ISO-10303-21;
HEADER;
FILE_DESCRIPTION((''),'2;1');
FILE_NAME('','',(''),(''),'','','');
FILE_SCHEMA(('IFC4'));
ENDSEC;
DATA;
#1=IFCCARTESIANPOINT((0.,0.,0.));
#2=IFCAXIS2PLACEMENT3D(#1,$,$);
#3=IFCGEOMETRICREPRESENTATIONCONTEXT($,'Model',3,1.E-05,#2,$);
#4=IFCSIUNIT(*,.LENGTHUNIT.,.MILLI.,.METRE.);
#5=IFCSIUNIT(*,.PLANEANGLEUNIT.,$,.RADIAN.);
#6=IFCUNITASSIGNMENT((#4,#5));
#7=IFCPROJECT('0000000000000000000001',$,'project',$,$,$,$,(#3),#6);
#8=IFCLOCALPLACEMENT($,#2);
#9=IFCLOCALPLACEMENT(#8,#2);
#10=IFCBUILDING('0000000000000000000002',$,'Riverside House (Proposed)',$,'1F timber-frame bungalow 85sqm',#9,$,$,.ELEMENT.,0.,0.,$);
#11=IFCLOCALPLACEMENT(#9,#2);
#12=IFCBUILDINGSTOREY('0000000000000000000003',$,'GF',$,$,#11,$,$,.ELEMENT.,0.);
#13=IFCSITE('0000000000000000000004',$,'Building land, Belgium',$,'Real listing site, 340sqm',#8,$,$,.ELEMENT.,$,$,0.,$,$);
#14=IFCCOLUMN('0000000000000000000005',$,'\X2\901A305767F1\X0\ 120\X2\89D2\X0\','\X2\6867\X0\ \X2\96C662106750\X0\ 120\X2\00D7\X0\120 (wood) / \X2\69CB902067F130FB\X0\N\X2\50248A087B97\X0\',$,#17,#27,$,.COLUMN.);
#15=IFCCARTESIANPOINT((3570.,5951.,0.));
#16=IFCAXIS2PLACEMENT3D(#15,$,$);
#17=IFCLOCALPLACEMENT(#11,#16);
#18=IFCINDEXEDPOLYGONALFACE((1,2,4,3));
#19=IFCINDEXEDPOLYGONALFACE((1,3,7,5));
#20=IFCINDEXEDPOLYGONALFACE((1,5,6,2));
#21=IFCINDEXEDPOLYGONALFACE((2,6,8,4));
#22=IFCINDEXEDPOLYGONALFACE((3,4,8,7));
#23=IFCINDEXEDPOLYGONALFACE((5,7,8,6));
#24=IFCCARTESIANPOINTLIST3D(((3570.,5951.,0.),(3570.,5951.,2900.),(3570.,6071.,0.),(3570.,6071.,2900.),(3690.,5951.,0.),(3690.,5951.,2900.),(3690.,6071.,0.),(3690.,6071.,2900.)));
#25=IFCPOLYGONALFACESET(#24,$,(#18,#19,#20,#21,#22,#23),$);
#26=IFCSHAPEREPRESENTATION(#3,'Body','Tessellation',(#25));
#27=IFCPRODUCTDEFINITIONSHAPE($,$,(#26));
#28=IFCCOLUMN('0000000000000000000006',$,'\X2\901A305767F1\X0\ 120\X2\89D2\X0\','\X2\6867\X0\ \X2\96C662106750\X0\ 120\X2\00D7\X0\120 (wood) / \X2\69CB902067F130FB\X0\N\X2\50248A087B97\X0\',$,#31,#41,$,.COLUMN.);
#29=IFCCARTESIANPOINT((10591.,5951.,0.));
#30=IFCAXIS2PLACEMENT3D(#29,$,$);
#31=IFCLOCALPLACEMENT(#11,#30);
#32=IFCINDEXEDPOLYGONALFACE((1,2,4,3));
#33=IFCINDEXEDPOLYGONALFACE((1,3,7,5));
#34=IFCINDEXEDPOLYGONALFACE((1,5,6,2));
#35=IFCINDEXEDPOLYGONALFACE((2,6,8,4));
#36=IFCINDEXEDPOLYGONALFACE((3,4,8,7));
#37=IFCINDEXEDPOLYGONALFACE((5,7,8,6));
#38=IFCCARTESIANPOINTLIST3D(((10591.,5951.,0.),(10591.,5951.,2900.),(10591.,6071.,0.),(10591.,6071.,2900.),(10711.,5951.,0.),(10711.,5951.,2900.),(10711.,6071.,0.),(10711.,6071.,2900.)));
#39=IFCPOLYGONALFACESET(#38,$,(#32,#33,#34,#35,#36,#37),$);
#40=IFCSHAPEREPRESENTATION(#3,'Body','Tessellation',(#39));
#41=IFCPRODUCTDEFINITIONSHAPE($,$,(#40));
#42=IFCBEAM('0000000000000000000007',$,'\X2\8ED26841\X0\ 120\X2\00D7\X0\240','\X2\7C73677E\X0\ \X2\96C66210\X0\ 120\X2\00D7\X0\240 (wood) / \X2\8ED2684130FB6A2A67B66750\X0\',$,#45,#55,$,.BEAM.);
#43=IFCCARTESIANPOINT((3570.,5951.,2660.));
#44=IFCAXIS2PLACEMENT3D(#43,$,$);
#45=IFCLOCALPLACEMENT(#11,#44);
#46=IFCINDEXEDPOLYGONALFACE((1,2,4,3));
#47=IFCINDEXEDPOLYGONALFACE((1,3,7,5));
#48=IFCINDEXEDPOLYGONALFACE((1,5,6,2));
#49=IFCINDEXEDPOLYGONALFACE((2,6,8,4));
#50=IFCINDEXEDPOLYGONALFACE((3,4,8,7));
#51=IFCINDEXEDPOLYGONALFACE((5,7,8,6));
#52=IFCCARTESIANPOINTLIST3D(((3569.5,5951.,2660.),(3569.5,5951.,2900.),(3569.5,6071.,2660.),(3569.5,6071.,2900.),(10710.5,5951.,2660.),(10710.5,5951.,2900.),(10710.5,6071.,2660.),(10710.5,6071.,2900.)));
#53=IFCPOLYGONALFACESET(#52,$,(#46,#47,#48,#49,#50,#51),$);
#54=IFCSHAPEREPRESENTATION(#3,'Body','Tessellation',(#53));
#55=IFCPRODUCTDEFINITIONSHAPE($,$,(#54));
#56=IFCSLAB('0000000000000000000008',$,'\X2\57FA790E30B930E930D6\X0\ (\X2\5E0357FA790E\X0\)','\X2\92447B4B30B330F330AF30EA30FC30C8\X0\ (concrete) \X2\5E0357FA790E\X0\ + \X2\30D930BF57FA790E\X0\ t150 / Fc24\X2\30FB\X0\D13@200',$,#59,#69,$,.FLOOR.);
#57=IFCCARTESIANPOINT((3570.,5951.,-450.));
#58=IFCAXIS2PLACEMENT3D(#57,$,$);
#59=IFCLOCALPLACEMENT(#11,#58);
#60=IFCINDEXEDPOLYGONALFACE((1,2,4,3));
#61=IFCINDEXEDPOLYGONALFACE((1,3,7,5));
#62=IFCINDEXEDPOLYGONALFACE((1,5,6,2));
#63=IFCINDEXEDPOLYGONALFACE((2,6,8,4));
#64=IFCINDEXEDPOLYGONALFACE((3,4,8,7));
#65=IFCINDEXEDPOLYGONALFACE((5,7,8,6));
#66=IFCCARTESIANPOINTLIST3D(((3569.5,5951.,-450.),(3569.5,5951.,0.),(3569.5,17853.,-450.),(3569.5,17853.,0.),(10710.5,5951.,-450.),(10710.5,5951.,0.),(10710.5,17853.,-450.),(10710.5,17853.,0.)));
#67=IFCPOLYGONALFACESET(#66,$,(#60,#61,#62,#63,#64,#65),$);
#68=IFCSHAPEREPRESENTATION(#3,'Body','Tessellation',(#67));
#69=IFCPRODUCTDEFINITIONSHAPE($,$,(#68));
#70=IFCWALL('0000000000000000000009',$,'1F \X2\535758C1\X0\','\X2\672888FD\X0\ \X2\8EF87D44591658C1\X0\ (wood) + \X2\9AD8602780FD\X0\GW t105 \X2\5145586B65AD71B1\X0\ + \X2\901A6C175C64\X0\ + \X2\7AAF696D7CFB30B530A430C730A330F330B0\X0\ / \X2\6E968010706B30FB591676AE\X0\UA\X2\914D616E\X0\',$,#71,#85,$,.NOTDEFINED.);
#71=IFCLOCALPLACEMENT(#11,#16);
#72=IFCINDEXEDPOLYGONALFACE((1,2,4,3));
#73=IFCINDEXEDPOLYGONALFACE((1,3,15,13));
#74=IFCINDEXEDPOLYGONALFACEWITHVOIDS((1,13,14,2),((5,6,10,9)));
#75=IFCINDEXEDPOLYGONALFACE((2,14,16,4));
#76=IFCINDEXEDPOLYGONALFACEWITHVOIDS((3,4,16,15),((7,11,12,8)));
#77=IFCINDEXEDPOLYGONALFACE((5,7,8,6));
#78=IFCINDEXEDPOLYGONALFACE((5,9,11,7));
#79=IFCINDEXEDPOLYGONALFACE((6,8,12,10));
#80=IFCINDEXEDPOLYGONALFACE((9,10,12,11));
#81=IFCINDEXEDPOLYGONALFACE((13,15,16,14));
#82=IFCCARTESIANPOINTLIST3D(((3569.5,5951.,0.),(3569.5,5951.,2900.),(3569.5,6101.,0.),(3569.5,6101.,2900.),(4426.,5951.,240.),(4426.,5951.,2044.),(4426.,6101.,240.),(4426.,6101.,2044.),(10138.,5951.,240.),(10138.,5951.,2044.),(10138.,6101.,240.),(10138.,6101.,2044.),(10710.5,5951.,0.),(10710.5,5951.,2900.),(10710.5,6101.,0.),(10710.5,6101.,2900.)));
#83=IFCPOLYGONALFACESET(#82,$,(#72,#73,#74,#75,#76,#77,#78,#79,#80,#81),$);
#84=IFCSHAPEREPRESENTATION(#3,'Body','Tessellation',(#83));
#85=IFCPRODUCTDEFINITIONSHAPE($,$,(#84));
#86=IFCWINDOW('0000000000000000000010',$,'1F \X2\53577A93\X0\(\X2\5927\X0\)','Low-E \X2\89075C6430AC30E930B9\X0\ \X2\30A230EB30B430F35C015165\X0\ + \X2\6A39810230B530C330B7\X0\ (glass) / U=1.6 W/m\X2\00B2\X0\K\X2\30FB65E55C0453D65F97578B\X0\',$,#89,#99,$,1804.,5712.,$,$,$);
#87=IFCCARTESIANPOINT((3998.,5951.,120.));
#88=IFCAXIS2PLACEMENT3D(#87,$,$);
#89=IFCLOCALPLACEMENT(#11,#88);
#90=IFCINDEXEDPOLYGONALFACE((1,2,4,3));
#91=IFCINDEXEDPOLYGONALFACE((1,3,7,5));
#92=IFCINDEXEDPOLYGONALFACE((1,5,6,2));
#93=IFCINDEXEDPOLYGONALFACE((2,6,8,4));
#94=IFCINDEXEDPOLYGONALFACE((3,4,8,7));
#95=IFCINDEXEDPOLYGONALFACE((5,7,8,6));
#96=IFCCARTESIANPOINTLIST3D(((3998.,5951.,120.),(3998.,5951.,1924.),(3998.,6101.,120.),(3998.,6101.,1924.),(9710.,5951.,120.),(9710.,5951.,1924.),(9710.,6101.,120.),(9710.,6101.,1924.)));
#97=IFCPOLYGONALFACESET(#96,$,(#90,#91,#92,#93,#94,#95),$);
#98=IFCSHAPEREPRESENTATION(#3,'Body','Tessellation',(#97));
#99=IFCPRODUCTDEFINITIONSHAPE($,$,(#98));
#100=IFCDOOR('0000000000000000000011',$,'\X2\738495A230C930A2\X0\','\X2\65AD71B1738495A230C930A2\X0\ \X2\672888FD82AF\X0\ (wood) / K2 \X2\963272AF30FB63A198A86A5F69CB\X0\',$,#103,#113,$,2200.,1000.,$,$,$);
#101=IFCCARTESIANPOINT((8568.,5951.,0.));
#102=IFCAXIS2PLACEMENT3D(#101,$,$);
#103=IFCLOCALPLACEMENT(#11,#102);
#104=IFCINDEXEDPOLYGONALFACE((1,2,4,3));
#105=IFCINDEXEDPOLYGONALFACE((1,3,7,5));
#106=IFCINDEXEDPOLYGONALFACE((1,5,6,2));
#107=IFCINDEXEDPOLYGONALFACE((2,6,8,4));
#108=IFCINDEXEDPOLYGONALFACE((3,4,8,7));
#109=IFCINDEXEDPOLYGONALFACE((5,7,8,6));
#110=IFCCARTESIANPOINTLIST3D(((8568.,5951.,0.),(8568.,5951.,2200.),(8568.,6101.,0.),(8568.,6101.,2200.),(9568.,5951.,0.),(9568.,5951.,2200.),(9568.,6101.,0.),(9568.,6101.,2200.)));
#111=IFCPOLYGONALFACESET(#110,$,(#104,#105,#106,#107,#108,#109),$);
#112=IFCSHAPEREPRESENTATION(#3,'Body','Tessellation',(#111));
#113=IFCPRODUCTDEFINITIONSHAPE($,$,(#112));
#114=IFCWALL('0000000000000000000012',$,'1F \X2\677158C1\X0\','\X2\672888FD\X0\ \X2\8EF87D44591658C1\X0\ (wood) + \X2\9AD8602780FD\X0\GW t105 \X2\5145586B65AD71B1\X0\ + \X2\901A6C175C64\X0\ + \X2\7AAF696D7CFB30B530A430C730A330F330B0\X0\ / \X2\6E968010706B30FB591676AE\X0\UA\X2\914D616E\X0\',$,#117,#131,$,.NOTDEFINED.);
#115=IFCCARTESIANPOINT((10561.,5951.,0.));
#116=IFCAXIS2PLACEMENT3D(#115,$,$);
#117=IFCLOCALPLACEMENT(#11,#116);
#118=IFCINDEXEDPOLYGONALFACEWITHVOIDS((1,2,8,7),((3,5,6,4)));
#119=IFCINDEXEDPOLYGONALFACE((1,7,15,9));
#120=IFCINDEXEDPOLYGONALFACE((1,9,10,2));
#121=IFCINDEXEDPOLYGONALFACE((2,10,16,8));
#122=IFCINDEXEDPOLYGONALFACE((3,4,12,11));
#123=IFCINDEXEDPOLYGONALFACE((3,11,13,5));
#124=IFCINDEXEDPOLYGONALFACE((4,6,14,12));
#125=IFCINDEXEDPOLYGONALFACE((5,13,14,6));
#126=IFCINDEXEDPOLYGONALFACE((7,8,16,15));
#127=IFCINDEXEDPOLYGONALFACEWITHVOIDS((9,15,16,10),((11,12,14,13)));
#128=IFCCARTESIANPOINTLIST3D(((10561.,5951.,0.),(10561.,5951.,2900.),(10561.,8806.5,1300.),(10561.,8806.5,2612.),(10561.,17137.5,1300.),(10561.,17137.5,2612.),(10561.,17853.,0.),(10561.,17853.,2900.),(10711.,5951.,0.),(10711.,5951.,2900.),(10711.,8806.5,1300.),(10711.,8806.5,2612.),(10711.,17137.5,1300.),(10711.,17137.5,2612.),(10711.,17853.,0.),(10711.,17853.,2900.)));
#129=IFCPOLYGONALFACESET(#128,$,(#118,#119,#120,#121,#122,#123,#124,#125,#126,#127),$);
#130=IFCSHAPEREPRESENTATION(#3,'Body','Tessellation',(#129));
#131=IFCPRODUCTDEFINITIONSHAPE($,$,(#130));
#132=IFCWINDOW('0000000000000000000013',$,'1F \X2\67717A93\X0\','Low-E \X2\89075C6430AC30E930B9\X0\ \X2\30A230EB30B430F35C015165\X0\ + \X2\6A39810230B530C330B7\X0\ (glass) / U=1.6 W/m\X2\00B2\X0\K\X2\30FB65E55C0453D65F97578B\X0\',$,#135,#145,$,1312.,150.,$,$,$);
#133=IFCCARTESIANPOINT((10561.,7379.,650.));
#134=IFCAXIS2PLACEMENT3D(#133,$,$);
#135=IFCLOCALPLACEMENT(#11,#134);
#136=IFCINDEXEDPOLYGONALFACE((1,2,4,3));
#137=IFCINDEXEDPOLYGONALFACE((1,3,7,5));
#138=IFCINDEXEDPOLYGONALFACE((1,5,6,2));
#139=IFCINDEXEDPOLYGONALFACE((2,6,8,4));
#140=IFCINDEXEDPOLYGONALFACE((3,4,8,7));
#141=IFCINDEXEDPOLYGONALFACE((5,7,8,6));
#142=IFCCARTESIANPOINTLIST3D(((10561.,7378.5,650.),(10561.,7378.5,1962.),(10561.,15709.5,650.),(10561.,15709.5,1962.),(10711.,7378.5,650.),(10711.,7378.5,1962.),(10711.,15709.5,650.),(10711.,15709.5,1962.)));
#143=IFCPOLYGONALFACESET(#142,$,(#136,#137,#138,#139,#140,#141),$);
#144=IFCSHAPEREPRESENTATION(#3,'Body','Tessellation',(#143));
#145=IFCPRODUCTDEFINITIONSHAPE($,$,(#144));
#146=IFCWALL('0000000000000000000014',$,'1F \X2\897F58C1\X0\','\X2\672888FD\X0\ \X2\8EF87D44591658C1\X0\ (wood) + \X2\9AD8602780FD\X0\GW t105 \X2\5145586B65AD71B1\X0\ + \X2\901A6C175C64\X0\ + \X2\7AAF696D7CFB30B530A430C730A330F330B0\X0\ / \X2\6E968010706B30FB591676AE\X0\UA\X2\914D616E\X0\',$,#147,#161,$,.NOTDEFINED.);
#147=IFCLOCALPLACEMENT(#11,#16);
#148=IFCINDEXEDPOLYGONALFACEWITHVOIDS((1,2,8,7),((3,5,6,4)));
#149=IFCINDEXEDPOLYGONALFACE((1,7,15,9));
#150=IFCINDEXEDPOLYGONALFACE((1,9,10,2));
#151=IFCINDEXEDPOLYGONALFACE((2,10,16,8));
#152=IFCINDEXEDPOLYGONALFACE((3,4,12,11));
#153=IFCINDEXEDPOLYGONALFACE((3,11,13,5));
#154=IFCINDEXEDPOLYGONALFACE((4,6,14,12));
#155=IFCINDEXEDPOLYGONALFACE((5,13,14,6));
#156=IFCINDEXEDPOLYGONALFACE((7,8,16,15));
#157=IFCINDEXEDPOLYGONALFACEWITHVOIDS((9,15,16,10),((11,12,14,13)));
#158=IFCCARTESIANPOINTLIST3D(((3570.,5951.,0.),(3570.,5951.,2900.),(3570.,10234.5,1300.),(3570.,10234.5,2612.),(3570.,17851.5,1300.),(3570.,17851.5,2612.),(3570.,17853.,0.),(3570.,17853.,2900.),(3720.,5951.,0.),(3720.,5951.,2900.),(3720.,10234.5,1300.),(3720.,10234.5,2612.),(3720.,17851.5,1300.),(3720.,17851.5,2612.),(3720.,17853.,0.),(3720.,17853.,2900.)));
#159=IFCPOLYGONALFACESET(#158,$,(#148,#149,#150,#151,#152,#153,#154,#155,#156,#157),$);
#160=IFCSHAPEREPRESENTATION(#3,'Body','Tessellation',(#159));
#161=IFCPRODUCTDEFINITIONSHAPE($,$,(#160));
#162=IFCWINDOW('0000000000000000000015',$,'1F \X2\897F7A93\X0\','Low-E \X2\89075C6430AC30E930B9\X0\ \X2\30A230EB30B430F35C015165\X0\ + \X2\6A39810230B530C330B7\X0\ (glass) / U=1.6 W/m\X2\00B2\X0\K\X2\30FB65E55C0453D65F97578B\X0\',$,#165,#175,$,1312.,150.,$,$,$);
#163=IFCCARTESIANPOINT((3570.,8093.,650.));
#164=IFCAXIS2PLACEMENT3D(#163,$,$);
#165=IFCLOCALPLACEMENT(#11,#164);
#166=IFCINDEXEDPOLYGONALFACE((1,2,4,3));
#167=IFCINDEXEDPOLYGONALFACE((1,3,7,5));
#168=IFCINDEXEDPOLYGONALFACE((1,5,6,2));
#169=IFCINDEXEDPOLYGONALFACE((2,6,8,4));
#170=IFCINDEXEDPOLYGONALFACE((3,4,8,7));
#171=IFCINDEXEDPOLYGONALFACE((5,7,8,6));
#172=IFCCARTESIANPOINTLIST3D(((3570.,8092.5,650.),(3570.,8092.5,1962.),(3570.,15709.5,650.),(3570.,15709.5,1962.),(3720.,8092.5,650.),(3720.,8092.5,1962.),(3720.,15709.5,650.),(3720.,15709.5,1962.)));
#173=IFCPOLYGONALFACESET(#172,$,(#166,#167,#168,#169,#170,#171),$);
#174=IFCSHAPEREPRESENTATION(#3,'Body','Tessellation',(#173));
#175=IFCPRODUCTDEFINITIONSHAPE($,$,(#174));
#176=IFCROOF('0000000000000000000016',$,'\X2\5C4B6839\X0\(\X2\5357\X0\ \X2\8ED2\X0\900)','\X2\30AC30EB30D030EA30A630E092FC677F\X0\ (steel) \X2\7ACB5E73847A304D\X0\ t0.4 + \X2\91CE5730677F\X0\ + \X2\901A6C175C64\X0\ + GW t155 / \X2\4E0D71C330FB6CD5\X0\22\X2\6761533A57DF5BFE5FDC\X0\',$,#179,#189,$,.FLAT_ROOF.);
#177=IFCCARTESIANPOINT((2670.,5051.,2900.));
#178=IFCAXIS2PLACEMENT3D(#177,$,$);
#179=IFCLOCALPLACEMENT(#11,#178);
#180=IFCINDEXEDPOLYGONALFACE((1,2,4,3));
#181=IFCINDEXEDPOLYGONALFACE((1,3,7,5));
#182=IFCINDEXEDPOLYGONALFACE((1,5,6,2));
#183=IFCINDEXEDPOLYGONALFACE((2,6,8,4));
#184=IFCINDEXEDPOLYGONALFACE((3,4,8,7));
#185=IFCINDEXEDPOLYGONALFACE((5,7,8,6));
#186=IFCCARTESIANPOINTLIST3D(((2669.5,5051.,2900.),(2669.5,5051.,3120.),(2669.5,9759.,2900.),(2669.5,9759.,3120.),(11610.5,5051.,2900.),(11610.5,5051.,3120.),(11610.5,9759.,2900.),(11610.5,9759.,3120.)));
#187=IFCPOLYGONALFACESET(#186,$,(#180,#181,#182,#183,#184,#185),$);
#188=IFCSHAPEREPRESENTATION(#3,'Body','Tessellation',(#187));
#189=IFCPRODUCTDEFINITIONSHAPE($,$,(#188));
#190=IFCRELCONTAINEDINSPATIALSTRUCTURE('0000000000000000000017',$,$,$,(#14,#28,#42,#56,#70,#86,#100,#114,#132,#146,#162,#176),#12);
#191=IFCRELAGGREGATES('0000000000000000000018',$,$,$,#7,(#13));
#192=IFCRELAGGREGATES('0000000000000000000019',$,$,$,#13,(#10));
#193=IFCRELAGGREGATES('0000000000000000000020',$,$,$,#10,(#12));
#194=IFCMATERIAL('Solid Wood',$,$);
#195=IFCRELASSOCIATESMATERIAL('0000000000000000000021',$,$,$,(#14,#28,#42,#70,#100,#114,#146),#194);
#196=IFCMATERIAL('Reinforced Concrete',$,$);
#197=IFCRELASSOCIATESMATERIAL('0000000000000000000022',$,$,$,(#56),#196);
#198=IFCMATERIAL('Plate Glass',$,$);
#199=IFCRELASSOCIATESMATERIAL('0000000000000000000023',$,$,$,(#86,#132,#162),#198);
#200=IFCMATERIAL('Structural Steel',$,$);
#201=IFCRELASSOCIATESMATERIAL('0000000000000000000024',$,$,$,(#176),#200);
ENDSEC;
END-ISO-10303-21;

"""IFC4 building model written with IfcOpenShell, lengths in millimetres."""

from ifc_helpers import new_model, si_unit, frame, frame_2d, origin, place, context, project, spatial, rectangle, extrude, material, element, fill, save


model = new_model("IFC4")

# Units and contexts
model_context = context("Model", 3, precision=1e-05, world=origin())
ifc_project = project(units=[si_unit("LENGTHUNIT", "METRE", prefix="MILLI"), si_unit("PLANEANGLEUNIT", "RADIAN")], contexts=[model_context])

# Site, building, storey
site_placement = place(None, origin())
site = spatial("IfcSite", under=ifc_project, at=site_placement, Name="Building land, Belgium", ObjectType="Real listing site, 340sqm", CompositionType="ELEMENT", RefElevation=0.0)
building_placement = place(site_placement, origin())
building = spatial("IfcBuilding", under=site, at=building_placement, Name="Riverside House (Proposed)", ObjectType="1F timber-frame bungalow 85sqm", CompositionType="ELEMENT", ElevationOfRefHeight=0.0, ElevationOfTerrain=0.0)
storey_placement = place(building_placement, origin())
storey = spatial("IfcBuildingStorey", under=building, at=storey_placement, Name="GF", CompositionType="ELEMENT", Elevation=0.0)

# Columns
ifc_material_1 = material(Name="Solid Wood")
column_1_placement = place(storey_placement, frame((3570.0, 5951.0, 0.0)))
element("IfcColumn", 1, at=column_1_placement, inside=storey, material=ifc_material_1, Name="通し柱 120角", Description="桧 集成材 120×120 (wood) / 構造柱・N値計算", PredefinedType="COLUMN", context=model_context, shape_type="SweptSolid", body=[
    extrude(rectangle(XDim=120.0, YDim=120.0, at=frame_2d((60.0, 60.0))), frame((3570.0, 5951.0, 0.0)), (0.0, 0.0, 1.0), 2900.0),
])
column_2_placement = place(storey_placement, frame((10591.0, 5951.0, 0.0)))
element("IfcColumn", 2, at=column_2_placement, inside=storey, material=ifc_material_1, Name="通し柱 120角", Description="桧 集成材 120×120 (wood) / 構造柱・N値計算", PredefinedType="COLUMN", context=model_context, shape_type="SweptSolid", body=[
    extrude(rectangle(XDim=120.0, YDim=120.0, at=frame_2d((60.0, 60.0))), frame((10591.0, 5951.0, 0.0)), (0.0, 0.0, 1.0), 2900.0),
])

# Beam
beam_1_placement = place(storey_placement, frame((3570.0, 5951.0, 2660.0)))
element("IfcBeam", 3, at=beam_1_placement, inside=storey, material=ifc_material_1, Name="軒桁 120×240", Description="米松 集成 120×240 (wood) / 軒桁・横架材", PredefinedType="BEAM", context=model_context, shape_type="SweptSolid", body=[
    extrude(rectangle(XDim=7141.0, YDim=120.0, at=frame_2d((3570.0, 60.0))), frame((3570.0, 5951.0, 2660.0)), (0.0, 0.0, 1.0), 240.0),
])

# Slab
ifc_material_2 = material(Name="Reinforced Concrete")
slab_1_placement = place(storey_placement, frame((3570.0, 5951.0, -450.0)))
element("IfcSlab", 4, at=slab_1_placement, inside=storey, material=ifc_material_2, Name="基礎スラブ (布基礎)", Description="鉄筋コンクリート (concrete) 布基礎 + ベタ基礎 t150 / Fc24・D13@200", PredefinedType="FLOOR", context=model_context, shape_type="SweptSolid", body=[
    extrude(rectangle(XDim=7141.0, YDim=11902.0, at=frame_2d((3570.0, 5951.0))), frame((3570.0, 5951.0, -450.0)), (0.0, 0.0, 1.0), 450.0),
])

# Wall, openings, window, door
wall_1_placement = place(storey_placement, frame((3570.0, 5951.0, 0.0)))
wall_1 = element("IfcWall", 5, at=wall_1_placement, inside=storey, material=ifc_material_1, Name="1F 南壁", Description="木製 軸組外壁 (wood) + 高性能GW t105 充填断熱 + 通気層 + 窯業系サイディング / 準耐火・外皮UA配慮", PredefinedType="NOTDEFINED", context=model_context, shape_type="SweptSolid", body=[
    extrude(rectangle(XDim=7141.0, YDim=150.0, at=frame_2d((3570.0, 75.0))), frame((3570.0, 5951.0, 0.0)), (0.0, 0.0, 1.0), 2900.0),
])
opening_1_placement = place(storey_placement, frame((3998.0, 5951.0, 120.0)))
opening_1 = element("IfcOpeningElement", 6, at=opening_1_placement, cuts=wall_1, PredefinedType="NOTDEFINED", context=model_context, shape_type="SweptSolid", body=[
    extrude(rectangle(XDim=5712.0, YDim=150.0, at=frame_2d((2856.0, 75.0))), frame((3998.0, 5951.0, 120.0)), (0.0, 0.0, 1.0), 1804.0),
])
opening_2_placement = place(storey_placement, frame((8568.0, 5951.0, 0.0)))
opening_2 = element("IfcOpeningElement", 7, at=opening_2_placement, cuts=wall_1, PredefinedType="NOTDEFINED", context=model_context, shape_type="SweptSolid", body=[
    extrude(rectangle(XDim=1000.0, YDim=150.0, at=frame_2d((500.0, 75.0))), frame((8568.0, 5951.0, 0.0)), (0.0, 0.0, 1.0), 2200.0),
])
ifc_material_3 = material(Name="Plate Glass")
window_1_placement = place(storey_placement, frame((3998.0, 5951.0, 120.0)))
window_1 = element("IfcWindow", 8, at=window_1_placement, inside=storey, material=ifc_material_3, Name="1F 南窓(大)", Description="Low-E 複層ガラス アルゴン封入 + 樹脂サッシ (glass) / U=1.6 W/m²K・日射取得型", OverallHeight=1804.0, OverallWidth=5712.0, context=model_context, shape_type="SweptSolid", body=[
    extrude(rectangle(XDim=5712.0, YDim=150.0, at=frame_2d((2856.0, 75.0))), frame((3998.0, 5951.0, 120.0)), (0.0, 0.0, 1.0), 1804.0),
])
fill(opening_1, window_1)
door_placement = place(storey_placement, frame((8568.0, 5951.0, 0.0)))
door = element("IfcDoor", 9, at=door_placement, inside=storey, material=ifc_material_1, Name="玄関ドア", Description="断熱玄関ドア 木製芯 (wood) / K2 防犯・採風機構", OverallHeight=2200.0, OverallWidth=1000.0, context=model_context, shape_type="SweptSolid", body=[
    extrude(rectangle(XDim=1000.0, YDim=150.0, at=frame_2d((500.0, 75.0))), frame((8568.0, 5951.0, 0.0)), (0.0, 0.0, 1.0), 2200.0),
])
fill(opening_2, door)

# Walls, openings, windows
wall_2_placement = place(storey_placement, frame((10561.0, 5951.0, 0.0)))
wall_2 = element("IfcWall", 10, at=wall_2_placement, inside=storey, material=ifc_material_1, Name="1F 東壁", Description="木製 軸組外壁 (wood) + 高性能GW t105 充填断熱 + 通気層 + 窯業系サイディング / 準耐火・外皮UA配慮", PredefinedType="NOTDEFINED", context=model_context, shape_type="SweptSolid", body=[
    extrude(rectangle(XDim=150.0, YDim=11902.0, at=frame_2d((75.0, 5951.0))), frame((10561.0, 5951.0, 0.0)), (0.0, 0.0, 1.0), 2900.0),
])
opening_3_placement = place(storey_placement, frame((10561.0, 7379.0, 650.0)))
opening_3 = element("IfcOpeningElement", 11, at=opening_3_placement, cuts=wall_2, PredefinedType="NOTDEFINED", context=model_context, shape_type="SweptSolid", body=[
    extrude(rectangle(XDim=150.0, YDim=8331.0, at=frame_2d((75.0, 4165.0))), frame((10561.0, 7379.0, 650.0)), (0.0, 0.0, 1.0), 1312.0),
])
window_2_placement = place(storey_placement, frame((10561.0, 7379.0, 650.0)))
window_2 = element("IfcWindow", 12, at=window_2_placement, inside=storey, material=ifc_material_3, Name="1F 東窓", Description="Low-E 複層ガラス アルゴン封入 + 樹脂サッシ (glass) / U=1.6 W/m²K・日射取得型", OverallHeight=1312.0, OverallWidth=150.0, context=model_context, shape_type="SweptSolid", body=[
    extrude(rectangle(XDim=150.0, YDim=8331.0, at=frame_2d((75.0, 4165.0))), frame((10561.0, 7379.0, 650.0)), (0.0, 0.0, 1.0), 1312.0),
])
fill(opening_3, window_2)
wall_3_placement = place(storey_placement, frame((3570.0, 5951.0, 0.0)))
wall_3 = element("IfcWall", 13, at=wall_3_placement, inside=storey, material=ifc_material_1, Name="1F 西壁", Description="木製 軸組外壁 (wood) + 高性能GW t105 充填断熱 + 通気層 + 窯業系サイディング / 準耐火・外皮UA配慮", PredefinedType="NOTDEFINED", context=model_context, shape_type="SweptSolid", body=[
    extrude(rectangle(XDim=150.0, YDim=11902.0, at=frame_2d((75.0, 5951.0))), frame((3570.0, 5951.0, 0.0)), (0.0, 0.0, 1.0), 2900.0),
])
opening_4_placement = place(storey_placement, frame((3570.0, 8093.0, 650.0)))
opening_4 = element("IfcOpeningElement", 14, at=opening_4_placement, cuts=wall_3, PredefinedType="NOTDEFINED", context=model_context, shape_type="SweptSolid", body=[
    extrude(rectangle(XDim=150.0, YDim=7617.0, at=frame_2d((75.0, 3808.0))), frame((3570.0, 8093.0, 650.0)), (0.0, 0.0, 1.0), 1312.0),
])
window_3_placement = place(storey_placement, frame((3570.0, 8093.0, 650.0)))
window_3 = element("IfcWindow", 15, at=window_3_placement, inside=storey, material=ifc_material_3, Name="1F 西窓", Description="Low-E 複層ガラス アルゴン封入 + 樹脂サッシ (glass) / U=1.6 W/m²K・日射取得型", OverallHeight=1312.0, OverallWidth=150.0, context=model_context, shape_type="SweptSolid", body=[
    extrude(rectangle(XDim=150.0, YDim=7617.0, at=frame_2d((75.0, 3808.0))), frame((3570.0, 8093.0, 650.0)), (0.0, 0.0, 1.0), 1312.0),
])
fill(opening_4, window_3)

# Roof
ifc_material_4 = material(Name="Structural Steel")
roof_placement = place(storey_placement, frame((2670.0, 5051.0, 2900.0)))
element("IfcRoof", 16, at=roof_placement, inside=storey, material=ifc_material_4, Name="屋根(南 軒900)", Description="ガルバリウム鋼板 (steel) 立平葺き t0.4 + 野地板 + 通気層 + GW t155 / 不燃・法22条区域対応", PredefinedType="FLAT_ROOF", context=model_context, shape_type="SweptSolid", body=[
    extrude(rectangle(XDim=8941.0, YDim=4708.0, at=frame_2d((4470.0, 2354.0))), frame((2670.0, 5051.0, 2900.0)), (0.0, 0.0, 1.0), 220.0),
])

save(model, "model.ifc")
